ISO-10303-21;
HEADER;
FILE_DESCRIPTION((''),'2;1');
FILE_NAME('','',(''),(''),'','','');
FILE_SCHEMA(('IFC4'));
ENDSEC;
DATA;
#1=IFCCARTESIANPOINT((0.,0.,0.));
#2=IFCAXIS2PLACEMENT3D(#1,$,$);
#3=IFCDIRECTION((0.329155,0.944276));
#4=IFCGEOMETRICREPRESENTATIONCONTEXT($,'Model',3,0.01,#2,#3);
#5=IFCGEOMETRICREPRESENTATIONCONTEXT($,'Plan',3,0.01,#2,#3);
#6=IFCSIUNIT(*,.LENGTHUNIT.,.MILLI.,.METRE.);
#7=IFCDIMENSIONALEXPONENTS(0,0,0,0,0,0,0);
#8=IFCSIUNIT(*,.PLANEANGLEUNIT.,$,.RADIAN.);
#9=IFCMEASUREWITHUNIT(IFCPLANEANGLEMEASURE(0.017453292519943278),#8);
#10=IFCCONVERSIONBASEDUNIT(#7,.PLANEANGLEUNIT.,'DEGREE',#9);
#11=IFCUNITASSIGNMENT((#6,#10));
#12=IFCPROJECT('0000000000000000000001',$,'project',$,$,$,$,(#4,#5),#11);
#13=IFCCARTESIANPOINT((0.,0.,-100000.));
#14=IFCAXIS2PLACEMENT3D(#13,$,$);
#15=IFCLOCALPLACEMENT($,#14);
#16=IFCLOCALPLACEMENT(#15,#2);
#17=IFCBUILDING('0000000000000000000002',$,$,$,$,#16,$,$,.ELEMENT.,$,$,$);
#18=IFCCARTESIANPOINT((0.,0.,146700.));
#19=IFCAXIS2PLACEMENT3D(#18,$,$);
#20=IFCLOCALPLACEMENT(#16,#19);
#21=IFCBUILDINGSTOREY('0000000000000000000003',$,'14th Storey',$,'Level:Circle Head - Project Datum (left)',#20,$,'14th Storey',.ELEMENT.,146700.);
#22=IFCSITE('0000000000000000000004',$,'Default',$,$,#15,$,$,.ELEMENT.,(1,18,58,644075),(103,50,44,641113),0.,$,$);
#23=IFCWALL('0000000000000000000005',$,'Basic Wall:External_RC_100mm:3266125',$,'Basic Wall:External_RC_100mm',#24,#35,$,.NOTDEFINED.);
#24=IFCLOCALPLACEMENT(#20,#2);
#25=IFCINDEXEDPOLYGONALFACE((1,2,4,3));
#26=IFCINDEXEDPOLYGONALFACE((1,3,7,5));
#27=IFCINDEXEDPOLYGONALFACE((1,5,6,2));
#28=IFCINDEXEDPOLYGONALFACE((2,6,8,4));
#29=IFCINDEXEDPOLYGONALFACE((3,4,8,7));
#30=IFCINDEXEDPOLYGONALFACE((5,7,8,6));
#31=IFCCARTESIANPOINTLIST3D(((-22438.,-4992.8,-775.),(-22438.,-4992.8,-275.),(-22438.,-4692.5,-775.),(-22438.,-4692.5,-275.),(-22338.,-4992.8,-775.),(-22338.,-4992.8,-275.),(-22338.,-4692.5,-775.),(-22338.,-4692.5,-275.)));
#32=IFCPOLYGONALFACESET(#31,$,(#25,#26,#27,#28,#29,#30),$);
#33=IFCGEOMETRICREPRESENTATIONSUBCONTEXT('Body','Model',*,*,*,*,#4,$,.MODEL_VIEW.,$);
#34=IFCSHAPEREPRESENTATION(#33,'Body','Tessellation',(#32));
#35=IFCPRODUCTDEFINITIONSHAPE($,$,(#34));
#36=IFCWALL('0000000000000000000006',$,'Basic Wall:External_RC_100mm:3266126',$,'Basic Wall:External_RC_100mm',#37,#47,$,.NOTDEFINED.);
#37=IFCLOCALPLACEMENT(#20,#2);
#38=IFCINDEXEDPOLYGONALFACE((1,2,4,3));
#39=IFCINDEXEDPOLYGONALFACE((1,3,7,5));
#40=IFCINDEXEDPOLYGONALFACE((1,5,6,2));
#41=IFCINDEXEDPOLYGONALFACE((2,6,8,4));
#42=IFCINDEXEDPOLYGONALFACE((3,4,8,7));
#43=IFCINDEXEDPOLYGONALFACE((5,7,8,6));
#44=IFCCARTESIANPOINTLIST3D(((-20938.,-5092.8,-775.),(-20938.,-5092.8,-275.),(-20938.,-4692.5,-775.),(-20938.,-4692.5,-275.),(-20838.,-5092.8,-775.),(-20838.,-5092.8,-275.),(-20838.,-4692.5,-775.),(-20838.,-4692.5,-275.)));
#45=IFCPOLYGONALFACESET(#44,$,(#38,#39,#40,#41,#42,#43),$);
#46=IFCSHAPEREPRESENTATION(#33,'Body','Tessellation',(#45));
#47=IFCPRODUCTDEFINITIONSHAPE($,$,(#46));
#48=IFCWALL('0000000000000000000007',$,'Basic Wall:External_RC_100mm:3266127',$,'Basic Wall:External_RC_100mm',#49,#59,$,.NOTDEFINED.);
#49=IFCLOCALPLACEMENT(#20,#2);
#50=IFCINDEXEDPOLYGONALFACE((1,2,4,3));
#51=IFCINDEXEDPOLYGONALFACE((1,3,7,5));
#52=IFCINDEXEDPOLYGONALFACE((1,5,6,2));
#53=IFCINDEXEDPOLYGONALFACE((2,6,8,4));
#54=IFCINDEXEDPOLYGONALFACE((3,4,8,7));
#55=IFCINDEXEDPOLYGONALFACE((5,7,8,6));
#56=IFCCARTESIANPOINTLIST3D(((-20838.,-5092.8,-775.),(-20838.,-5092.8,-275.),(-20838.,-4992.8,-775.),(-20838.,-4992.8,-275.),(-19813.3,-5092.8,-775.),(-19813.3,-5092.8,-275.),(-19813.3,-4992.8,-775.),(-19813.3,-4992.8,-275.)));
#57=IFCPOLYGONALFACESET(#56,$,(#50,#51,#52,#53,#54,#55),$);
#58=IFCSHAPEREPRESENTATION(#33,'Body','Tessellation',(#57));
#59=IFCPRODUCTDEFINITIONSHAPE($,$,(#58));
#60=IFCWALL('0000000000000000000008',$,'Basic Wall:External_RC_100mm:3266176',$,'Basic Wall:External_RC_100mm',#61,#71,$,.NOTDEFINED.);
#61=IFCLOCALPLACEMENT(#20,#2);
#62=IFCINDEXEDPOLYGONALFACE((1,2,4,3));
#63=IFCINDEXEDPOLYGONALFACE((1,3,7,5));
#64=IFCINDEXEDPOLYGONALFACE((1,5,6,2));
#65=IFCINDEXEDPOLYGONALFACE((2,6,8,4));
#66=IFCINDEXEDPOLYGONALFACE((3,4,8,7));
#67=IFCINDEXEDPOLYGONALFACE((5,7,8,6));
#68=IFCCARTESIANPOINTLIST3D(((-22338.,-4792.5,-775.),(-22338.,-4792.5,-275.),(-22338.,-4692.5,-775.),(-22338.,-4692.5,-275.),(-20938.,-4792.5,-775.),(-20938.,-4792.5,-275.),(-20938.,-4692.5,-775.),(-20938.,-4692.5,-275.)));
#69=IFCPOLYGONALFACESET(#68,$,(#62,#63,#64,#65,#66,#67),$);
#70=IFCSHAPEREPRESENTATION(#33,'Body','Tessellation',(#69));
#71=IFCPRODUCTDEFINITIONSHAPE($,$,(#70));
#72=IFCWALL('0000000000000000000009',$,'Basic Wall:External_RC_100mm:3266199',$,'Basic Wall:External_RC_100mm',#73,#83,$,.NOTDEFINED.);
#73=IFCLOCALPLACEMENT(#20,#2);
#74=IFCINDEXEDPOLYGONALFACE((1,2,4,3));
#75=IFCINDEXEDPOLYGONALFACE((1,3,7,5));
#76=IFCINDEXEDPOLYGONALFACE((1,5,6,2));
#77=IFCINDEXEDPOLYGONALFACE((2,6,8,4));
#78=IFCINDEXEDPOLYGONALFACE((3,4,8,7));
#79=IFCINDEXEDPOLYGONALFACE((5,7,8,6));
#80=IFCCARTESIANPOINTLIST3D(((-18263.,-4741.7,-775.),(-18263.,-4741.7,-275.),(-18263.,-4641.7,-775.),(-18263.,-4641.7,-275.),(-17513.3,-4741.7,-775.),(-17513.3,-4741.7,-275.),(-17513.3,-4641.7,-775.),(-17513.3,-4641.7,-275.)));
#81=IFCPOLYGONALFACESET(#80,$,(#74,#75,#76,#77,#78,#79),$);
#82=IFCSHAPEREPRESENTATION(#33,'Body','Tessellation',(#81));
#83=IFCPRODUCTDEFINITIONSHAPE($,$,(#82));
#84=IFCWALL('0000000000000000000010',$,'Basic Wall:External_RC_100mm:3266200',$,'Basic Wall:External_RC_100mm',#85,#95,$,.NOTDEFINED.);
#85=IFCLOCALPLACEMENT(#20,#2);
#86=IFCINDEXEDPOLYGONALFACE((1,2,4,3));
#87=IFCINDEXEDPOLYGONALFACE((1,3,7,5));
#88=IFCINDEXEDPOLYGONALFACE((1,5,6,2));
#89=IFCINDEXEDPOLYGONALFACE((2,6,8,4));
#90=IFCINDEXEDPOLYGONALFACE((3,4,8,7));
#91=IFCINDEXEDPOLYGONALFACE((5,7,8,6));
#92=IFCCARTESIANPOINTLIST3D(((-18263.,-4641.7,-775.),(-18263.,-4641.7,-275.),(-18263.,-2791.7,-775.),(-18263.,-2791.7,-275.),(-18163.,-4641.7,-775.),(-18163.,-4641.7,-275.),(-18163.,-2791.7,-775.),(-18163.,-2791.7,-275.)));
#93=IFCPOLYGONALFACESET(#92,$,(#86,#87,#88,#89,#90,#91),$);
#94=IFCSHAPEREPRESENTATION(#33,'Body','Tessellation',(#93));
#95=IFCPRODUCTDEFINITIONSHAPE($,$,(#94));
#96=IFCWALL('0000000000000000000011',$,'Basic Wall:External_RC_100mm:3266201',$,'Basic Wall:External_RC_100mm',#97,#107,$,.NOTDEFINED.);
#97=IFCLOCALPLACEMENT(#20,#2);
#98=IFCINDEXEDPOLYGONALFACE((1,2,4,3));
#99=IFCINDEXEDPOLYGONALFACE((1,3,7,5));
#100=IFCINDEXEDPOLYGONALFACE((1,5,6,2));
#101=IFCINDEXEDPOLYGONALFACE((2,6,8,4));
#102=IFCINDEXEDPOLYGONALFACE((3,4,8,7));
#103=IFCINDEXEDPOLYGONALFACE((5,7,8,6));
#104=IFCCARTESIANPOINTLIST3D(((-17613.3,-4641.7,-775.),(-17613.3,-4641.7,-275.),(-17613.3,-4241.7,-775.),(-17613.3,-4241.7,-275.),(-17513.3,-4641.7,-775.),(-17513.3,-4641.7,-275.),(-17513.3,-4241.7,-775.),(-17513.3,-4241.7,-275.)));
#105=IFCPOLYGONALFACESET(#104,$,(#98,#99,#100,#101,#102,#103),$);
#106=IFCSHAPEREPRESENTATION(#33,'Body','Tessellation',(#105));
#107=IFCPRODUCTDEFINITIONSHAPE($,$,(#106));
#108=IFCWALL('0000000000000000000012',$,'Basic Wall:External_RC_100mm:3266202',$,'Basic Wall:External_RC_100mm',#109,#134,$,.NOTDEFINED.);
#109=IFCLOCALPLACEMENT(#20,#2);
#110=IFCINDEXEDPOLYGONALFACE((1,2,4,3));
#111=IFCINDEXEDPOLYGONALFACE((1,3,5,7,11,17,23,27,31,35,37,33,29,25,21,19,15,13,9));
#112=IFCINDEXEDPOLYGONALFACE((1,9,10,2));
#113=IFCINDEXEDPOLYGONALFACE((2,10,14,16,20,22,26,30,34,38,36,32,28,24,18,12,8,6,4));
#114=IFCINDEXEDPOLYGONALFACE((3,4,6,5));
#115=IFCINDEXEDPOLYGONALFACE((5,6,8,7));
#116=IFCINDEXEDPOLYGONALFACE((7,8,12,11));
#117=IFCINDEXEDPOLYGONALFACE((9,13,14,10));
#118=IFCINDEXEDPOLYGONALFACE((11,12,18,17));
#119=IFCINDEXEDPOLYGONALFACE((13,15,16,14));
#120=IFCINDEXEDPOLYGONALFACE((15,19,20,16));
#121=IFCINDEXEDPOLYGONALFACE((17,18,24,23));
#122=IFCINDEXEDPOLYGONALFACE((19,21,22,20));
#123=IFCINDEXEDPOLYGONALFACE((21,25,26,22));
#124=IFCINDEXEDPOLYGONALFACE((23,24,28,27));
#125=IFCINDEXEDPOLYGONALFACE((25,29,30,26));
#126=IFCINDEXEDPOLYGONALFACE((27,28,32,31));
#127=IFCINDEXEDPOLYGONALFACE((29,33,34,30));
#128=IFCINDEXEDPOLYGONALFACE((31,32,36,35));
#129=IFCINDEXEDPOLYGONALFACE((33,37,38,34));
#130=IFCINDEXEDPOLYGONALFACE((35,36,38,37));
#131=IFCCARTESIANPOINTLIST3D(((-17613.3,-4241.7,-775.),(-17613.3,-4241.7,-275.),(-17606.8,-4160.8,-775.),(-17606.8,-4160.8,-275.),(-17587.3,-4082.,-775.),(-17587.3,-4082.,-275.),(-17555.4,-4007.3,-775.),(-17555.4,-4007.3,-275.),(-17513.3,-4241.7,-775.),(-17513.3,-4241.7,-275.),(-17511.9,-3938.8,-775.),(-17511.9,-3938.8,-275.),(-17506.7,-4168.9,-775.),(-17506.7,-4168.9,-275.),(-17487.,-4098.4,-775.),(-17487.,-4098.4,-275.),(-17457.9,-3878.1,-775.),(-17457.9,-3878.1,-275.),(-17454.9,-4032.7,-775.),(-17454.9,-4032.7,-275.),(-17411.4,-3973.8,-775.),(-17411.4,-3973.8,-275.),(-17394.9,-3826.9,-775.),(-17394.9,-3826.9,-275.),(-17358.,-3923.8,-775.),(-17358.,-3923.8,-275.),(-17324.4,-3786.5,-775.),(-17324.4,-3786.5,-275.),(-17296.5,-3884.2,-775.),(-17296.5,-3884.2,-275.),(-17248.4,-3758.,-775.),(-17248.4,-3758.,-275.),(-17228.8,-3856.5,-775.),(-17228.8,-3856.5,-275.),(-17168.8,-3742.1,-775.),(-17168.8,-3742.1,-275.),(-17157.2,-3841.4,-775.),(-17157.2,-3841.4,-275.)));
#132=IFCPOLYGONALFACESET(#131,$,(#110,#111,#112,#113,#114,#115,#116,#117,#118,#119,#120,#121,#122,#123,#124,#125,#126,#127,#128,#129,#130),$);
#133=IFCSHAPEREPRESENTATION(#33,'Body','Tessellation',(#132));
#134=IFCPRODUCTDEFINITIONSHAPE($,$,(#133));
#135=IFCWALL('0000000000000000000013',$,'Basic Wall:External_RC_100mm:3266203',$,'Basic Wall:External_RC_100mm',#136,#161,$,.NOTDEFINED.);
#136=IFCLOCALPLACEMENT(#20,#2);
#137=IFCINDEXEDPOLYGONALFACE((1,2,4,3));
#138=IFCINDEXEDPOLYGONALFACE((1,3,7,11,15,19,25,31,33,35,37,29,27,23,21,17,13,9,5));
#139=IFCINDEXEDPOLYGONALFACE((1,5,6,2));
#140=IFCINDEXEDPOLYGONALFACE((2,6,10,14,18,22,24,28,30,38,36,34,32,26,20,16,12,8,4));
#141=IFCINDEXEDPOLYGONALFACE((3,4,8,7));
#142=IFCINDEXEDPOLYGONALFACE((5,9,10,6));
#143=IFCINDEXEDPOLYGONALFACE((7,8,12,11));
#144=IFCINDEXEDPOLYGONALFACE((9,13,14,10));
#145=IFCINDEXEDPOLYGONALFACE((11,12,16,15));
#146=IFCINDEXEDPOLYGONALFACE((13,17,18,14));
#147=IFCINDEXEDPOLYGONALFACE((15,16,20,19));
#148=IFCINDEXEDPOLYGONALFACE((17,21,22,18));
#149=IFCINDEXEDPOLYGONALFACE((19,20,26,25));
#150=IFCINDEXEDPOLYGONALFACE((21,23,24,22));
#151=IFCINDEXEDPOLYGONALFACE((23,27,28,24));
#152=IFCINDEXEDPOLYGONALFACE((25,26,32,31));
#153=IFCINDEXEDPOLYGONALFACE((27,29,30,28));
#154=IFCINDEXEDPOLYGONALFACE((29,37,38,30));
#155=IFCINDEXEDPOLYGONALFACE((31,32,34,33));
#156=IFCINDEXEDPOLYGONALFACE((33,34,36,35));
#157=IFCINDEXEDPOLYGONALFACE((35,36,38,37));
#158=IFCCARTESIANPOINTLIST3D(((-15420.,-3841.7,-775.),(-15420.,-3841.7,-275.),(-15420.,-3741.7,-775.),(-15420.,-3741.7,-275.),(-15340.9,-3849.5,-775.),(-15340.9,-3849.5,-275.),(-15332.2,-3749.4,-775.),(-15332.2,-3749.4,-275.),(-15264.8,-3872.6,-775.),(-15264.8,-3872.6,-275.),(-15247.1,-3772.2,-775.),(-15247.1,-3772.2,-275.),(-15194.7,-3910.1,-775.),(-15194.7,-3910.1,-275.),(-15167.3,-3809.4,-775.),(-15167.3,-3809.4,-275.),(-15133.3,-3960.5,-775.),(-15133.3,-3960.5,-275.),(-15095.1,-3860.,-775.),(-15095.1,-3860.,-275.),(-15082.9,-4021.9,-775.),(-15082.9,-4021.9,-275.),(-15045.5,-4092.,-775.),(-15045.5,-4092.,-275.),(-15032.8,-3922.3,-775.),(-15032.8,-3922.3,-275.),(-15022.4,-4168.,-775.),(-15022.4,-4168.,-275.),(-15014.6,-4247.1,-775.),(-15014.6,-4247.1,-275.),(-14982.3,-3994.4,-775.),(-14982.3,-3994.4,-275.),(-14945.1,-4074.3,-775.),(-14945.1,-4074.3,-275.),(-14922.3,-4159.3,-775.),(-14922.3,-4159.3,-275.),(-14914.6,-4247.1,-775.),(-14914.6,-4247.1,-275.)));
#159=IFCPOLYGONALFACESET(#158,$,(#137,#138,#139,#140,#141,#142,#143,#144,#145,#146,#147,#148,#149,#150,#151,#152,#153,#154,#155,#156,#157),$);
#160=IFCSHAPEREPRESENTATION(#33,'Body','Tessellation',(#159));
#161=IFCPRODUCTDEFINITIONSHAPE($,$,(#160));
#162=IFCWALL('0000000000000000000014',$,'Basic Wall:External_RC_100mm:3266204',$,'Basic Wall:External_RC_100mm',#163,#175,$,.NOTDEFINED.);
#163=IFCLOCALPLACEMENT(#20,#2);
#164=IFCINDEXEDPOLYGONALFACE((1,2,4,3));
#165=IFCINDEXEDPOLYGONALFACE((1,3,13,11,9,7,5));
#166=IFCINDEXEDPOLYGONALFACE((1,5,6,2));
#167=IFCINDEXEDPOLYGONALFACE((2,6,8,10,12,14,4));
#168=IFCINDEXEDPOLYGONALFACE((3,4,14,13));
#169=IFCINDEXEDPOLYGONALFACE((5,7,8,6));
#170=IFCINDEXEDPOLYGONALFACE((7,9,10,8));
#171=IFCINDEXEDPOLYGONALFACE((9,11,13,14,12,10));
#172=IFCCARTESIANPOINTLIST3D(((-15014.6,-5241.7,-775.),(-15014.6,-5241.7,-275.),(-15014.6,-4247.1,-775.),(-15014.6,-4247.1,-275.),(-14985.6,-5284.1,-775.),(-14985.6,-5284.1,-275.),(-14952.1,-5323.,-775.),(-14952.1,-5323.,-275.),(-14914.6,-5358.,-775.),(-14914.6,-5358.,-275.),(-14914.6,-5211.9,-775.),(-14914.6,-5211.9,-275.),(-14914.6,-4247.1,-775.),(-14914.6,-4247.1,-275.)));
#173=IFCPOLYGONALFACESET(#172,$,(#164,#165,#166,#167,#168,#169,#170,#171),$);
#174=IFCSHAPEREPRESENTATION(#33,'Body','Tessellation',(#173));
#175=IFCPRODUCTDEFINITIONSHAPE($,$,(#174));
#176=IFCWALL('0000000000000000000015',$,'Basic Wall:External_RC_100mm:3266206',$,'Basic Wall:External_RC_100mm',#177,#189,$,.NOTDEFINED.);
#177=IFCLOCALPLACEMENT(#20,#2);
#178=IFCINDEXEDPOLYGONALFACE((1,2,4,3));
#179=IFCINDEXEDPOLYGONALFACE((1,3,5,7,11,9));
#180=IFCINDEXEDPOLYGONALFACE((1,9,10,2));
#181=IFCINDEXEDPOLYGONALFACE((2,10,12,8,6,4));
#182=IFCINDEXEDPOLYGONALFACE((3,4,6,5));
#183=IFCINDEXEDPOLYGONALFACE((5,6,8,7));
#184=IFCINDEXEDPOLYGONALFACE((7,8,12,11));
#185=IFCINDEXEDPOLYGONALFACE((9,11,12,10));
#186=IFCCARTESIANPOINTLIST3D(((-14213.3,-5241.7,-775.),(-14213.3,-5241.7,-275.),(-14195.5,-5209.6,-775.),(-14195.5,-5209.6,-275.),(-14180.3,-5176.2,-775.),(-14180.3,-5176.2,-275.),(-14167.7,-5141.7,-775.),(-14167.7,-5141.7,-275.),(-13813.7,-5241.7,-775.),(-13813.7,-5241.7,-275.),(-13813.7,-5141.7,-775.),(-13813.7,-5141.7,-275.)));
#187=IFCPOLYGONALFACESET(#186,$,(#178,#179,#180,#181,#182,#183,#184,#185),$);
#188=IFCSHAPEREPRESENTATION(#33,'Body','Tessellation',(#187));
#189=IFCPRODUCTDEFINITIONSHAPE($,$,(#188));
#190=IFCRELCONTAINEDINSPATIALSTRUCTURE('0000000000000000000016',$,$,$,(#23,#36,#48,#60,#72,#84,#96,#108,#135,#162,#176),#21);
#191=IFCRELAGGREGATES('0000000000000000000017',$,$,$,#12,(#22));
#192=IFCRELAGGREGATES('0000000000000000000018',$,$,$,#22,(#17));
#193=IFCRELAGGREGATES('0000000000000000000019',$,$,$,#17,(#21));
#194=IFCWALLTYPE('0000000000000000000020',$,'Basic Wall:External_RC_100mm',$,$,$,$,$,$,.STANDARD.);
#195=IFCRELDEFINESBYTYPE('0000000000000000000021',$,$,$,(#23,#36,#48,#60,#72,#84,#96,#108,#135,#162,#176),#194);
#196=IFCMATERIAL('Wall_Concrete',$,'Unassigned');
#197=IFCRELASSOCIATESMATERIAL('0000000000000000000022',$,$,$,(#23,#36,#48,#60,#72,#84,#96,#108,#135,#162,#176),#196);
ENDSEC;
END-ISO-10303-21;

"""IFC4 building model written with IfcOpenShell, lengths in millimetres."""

from ifc_helpers import new_model, entity, si_unit, converted_unit, direction, frame, origin, place, context, subcontext, project, spatial, line, arc, indexed_curve, outline, extrude, material, type_object, element, save


model = new_model("IFC4")

# Units and contexts
model_context = context("Model", 3, precision=0.01, world=origin(), true_north=direction((0.329155, 0.944276)))
plan_context = context("Plan", 3, precision=0.01, world=origin(), true_north=direction((0.329155, 0.944276)))
body_context = subcontext(model_context, "Body", "Model", "MODEL_VIEW")
ifc_project = project(units=[si_unit("LENGTHUNIT", "METRE", prefix="MILLI"), converted_unit("PLANEANGLEUNIT", "DEGREE", entity("IfcPlaneAngleMeasure", 0.017453292519943278), si_unit("PLANEANGLEUNIT", "RADIAN"), dimensions=[0, 0, 0, 0, 0, 0, 0])], contexts=[model_context, plan_context])

# Site, building, storey
site_placement = place(None, frame((0.0, 0.0, -100000.0)))
site = spatial("IfcSite", under=ifc_project, at=site_placement, Name="Default", CompositionType="ELEMENT", RefLatitude=(1, 18, 58, 644075), RefLongitude=(103, 50, 44, 641113), RefElevation=0.0)
building_placement = place(site_placement, origin())
building = spatial("IfcBuilding", under=site, at=building_placement, CompositionType="ELEMENT")
storey_placement = place(building_placement, frame((0.0, 0.0, 146700.0)))
storey = spatial("IfcBuildingStorey", under=building, at=storey_placement, Name="14th Storey", ObjectType="Level:Circle Head - Project Datum (left)", LongName="14th Storey", CompositionType="ELEMENT", Elevation=146700.0)

# Walls
ifc_material_1 = material(Name="Wall_Concrete", Category="Unassigned")
wall_type_1 = type_object("IfcWallType", Name="Basic Wall:External_RC_100mm", PredefinedType="STANDARD")
wall_1_placement = place(storey_placement, frame((-22388.0, -4992.8, -775.0), z_axis=(0.0, 0.0, 1.0), x_axis=(0.0, 1.0, 0.0)))
element("IfcWall", 1, at=wall_1_placement, inside=storey, type_object=wall_type_1, material=ifc_material_1, Name="Basic Wall:External_RC_100mm:3266125", ObjectType="Basic Wall:External_RC_100mm", PredefinedType="NOTDEFINED", context=body_context, shape_type="SweptSolid", body=[
    extrude(outline(indexed_curve([(300.3, 50.0), (0.0, 50.0), (0.0, -50.0), (300.3, -50.0), (300.3, 50.0)], self_intersect=False)), origin(), (0.0, 0.0, 1.0), 500.0),
])
wall_2_placement = place(storey_placement, frame((-20888.0, -4692.5, -775.0), z_axis=(0.0, 0.0, 1.0), x_axis=(0.0, -1.0, 0.0)))
element("IfcWall", 2, at=wall_2_placement, inside=storey, type_object=wall_type_1, material=ifc_material_1, Name="Basic Wall:External_RC_100mm:3266126", ObjectType="Basic Wall:External_RC_100mm", PredefinedType="NOTDEFINED", context=body_context, shape_type="SweptSolid", body=[
    extrude(outline(indexed_curve([(400.3, 50.0), (0.0, 50.0), (0.0, -50.0), (400.3, -50.0), (400.3, 50.0)], self_intersect=False)), origin(), (0.0, 0.0, 1.0), 500.0),
])
wall_3_placement = place(storey_placement, frame((-20838.0, -5042.8, -775.0)))
element("IfcWall", 3, at=wall_3_placement, inside=storey, type_object=wall_type_1, material=ifc_material_1, Name="Basic Wall:External_RC_100mm:3266127", ObjectType="Basic Wall:External_RC_100mm", PredefinedType="NOTDEFINED", context=body_context, shape_type="SweptSolid", body=[
    extrude(outline(indexed_curve([(1024.6, 50.0), (0.0, 50.0), (0.0, -50.0), (1024.6, -50.0), (1024.6, 50.0)], self_intersect=False)), origin(), (0.0, 0.0, 1.0), 500.0),
])
wall_4_placement = place(storey_placement, frame((-22338.0, -4742.5, -775.0)))
element("IfcWall", 4, at=wall_4_placement, inside=storey, type_object=wall_type_1, material=ifc_material_1, Name="Basic Wall:External_RC_100mm:3266176", ObjectType="Basic Wall:External_RC_100mm", PredefinedType="NOTDEFINED", context=body_context, shape_type="SweptSolid", body=[
    extrude(outline(indexed_curve([(1400.0, 50.0), (0.0, 50.0), (0.0, -50.0), (1400.0, -50.0), (1400.0, 50.0)], self_intersect=False)), origin(), (0.0, 0.0, 1.0), 500.0),
])
wall_5_placement = place(storey_placement, frame((-18263.0, -4691.7, -775.0)))
element("IfcWall", 5, at=wall_5_placement, inside=storey, type_object=wall_type_1, material=ifc_material_1, Name="Basic Wall:External_RC_100mm:3266199", ObjectType="Basic Wall:External_RC_100mm", PredefinedType="NOTDEFINED", context=body_context, shape_type="SweptSolid", body=[
    extrude(outline(indexed_curve([(749.6, 50.0), (0.0, 50.0), (0.0, -50.0), (749.6, -50.0), (749.6, 50.0)], self_intersect=False)), origin(), (0.0, 0.0, 1.0), 500.0),
])
wall_6_placement = place(storey_placement, frame((-18213.0, -2791.7, -775.0), z_axis=(0.0, 0.0, 1.0), x_axis=(0.0, -1.0, 0.0)))
element("IfcWall", 6, at=wall_6_placement, inside=storey, type_object=wall_type_1, material=ifc_material_1, Name="Basic Wall:External_RC_100mm:3266200", ObjectType="Basic Wall:External_RC_100mm", PredefinedType="NOTDEFINED", context=body_context, shape_type="SweptSolid", body=[
    extrude(outline(indexed_curve([(1850.0, 50.0), (0.0, 50.0), (0.0, -50.0), (1850.0, -50.0), (1850.0, 50.0)], self_intersect=False)), origin(), (0.0, 0.0, 1.0), 500.0),
])
wall_7_placement = place(storey_placement, frame((-17563.3, -4641.7, -775.0), z_axis=(0.0, 0.0, 1.0), x_axis=(0.0, 1.0, 0.0)))
element("IfcWall", 7, at=wall_7_placement, inside=storey, type_object=wall_type_1, material=ifc_material_1, Name="Basic Wall:External_RC_100mm:3266201", ObjectType="Basic Wall:External_RC_100mm", PredefinedType="NOTDEFINED", context=body_context, shape_type="SweptSolid", body=[
    extrude(outline(indexed_curve([(400.0, 50.0), (0.0, 50.0), (0.0, -50.0), (400.0, -50.0), (400.0, 50.0)], self_intersect=False)), origin(), (0.0, 0.0, 1.0), 500.0),
])
wall_8_placement = place(storey_placement, frame((-17563.3, -4241.7, -775.0)))
element("IfcWall", 8, at=wall_8_placement, inside=storey, type_object=wall_type_1, material=ifc_material_1, Name="Basic Wall:External_RC_100mm:3266202", ObjectType="Basic Wall:External_RC_100mm", PredefinedType="NOTDEFINED", context=body_context, shape_type="SweptSolid", body=[
    extrude(outline(indexed_curve([(394.5, 499.7), (77.2, 334.4), (-50.0, 0.0), (50.0, 0.0), (151.9, 267.9), (406.2, 400.3)], segments=[arc(1, 2, 3), line(3, 4), arc(4, 5, 6), line(6, 1)], self_intersect=False)), origin(), (0.0, 0.0, 1.0), 500.0),
])
wall_9_placement = place(storey_placement, frame((-15420.0, -3791.7, -775.0)))
element("IfcWall", 9, at=wall_9_placement, inside=storey, type_object=wall_type_1, material=ifc_material_1, Name="Basic Wall:External_RC_100mm:3266203", ObjectType="Basic Wall:External_RC_100mm", PredefinedType="NOTDEFINED", context=body_context, shape_type="SweptSolid", body=[
    extrude(outline(indexed_curve([(505.4, -455.4), (357.3, -98.0), (0.0, 50.0), (0.0, -50.0), (286.6, -168.7), (405.4, -455.4)], segments=[arc(1, 2, 3), line(3, 4), arc(4, 5, 6), line(6, 1)], self_intersect=False)), origin(), (0.0, 0.0, 1.0), 500.0),
])
wall_10_placement = place(storey_placement, frame((-14964.6, -4247.1, -775.0), z_axis=(0.0, 0.0, 1.0), x_axis=(0.0, -1.0, 0.0)))
element("IfcWall", 10, at=wall_10_placement, inside=storey, type_object=wall_type_1, material=ifc_material_1, Name="Basic Wall:External_RC_100mm:3266204", ObjectType="Basic Wall:External_RC_100mm", PredefinedType="NOTDEFINED", context=body_context, shape_type="SweptSolid", body=[
    extrude(outline(indexed_curve([(994.6, -50.0), (1056.9, -4.8), (1110.9, 50.0), (964.8, 50.0), (0.0, 50.0), (0.0, -50.0)], segments=[arc(1, 2, 3), line(3, 4, 5, 6, 1)], self_intersect=False)), origin(), (0.0, 0.0, 1.0), 500.0),
])
wall_11_placement = place(storey_placement, frame((-14213.3, -5191.7, -775.0)))
element("IfcWall", 11, at=wall_11_placement, inside=storey, type_object=wall_type_1, material=ifc_material_1, Name="Basic Wall:External_RC_100mm:3266206", ObjectType="Basic Wall:External_RC_100mm", PredefinedType="NOTDEFINED", context=body_context, shape_type="SweptSolid", body=[
    extrude(outline(indexed_curve([(399.6, -50.0), (399.6, 50.0), (45.7, 50.0), (25.8, -1.3), (0.0, -50.0)], segments=[line(1, 2, 3), arc(3, 4, 5), line(5, 1)], self_intersect=False)), origin(), (0.0, 0.0, 1.0), 500.0),
])

save(model, "model.ifc")
